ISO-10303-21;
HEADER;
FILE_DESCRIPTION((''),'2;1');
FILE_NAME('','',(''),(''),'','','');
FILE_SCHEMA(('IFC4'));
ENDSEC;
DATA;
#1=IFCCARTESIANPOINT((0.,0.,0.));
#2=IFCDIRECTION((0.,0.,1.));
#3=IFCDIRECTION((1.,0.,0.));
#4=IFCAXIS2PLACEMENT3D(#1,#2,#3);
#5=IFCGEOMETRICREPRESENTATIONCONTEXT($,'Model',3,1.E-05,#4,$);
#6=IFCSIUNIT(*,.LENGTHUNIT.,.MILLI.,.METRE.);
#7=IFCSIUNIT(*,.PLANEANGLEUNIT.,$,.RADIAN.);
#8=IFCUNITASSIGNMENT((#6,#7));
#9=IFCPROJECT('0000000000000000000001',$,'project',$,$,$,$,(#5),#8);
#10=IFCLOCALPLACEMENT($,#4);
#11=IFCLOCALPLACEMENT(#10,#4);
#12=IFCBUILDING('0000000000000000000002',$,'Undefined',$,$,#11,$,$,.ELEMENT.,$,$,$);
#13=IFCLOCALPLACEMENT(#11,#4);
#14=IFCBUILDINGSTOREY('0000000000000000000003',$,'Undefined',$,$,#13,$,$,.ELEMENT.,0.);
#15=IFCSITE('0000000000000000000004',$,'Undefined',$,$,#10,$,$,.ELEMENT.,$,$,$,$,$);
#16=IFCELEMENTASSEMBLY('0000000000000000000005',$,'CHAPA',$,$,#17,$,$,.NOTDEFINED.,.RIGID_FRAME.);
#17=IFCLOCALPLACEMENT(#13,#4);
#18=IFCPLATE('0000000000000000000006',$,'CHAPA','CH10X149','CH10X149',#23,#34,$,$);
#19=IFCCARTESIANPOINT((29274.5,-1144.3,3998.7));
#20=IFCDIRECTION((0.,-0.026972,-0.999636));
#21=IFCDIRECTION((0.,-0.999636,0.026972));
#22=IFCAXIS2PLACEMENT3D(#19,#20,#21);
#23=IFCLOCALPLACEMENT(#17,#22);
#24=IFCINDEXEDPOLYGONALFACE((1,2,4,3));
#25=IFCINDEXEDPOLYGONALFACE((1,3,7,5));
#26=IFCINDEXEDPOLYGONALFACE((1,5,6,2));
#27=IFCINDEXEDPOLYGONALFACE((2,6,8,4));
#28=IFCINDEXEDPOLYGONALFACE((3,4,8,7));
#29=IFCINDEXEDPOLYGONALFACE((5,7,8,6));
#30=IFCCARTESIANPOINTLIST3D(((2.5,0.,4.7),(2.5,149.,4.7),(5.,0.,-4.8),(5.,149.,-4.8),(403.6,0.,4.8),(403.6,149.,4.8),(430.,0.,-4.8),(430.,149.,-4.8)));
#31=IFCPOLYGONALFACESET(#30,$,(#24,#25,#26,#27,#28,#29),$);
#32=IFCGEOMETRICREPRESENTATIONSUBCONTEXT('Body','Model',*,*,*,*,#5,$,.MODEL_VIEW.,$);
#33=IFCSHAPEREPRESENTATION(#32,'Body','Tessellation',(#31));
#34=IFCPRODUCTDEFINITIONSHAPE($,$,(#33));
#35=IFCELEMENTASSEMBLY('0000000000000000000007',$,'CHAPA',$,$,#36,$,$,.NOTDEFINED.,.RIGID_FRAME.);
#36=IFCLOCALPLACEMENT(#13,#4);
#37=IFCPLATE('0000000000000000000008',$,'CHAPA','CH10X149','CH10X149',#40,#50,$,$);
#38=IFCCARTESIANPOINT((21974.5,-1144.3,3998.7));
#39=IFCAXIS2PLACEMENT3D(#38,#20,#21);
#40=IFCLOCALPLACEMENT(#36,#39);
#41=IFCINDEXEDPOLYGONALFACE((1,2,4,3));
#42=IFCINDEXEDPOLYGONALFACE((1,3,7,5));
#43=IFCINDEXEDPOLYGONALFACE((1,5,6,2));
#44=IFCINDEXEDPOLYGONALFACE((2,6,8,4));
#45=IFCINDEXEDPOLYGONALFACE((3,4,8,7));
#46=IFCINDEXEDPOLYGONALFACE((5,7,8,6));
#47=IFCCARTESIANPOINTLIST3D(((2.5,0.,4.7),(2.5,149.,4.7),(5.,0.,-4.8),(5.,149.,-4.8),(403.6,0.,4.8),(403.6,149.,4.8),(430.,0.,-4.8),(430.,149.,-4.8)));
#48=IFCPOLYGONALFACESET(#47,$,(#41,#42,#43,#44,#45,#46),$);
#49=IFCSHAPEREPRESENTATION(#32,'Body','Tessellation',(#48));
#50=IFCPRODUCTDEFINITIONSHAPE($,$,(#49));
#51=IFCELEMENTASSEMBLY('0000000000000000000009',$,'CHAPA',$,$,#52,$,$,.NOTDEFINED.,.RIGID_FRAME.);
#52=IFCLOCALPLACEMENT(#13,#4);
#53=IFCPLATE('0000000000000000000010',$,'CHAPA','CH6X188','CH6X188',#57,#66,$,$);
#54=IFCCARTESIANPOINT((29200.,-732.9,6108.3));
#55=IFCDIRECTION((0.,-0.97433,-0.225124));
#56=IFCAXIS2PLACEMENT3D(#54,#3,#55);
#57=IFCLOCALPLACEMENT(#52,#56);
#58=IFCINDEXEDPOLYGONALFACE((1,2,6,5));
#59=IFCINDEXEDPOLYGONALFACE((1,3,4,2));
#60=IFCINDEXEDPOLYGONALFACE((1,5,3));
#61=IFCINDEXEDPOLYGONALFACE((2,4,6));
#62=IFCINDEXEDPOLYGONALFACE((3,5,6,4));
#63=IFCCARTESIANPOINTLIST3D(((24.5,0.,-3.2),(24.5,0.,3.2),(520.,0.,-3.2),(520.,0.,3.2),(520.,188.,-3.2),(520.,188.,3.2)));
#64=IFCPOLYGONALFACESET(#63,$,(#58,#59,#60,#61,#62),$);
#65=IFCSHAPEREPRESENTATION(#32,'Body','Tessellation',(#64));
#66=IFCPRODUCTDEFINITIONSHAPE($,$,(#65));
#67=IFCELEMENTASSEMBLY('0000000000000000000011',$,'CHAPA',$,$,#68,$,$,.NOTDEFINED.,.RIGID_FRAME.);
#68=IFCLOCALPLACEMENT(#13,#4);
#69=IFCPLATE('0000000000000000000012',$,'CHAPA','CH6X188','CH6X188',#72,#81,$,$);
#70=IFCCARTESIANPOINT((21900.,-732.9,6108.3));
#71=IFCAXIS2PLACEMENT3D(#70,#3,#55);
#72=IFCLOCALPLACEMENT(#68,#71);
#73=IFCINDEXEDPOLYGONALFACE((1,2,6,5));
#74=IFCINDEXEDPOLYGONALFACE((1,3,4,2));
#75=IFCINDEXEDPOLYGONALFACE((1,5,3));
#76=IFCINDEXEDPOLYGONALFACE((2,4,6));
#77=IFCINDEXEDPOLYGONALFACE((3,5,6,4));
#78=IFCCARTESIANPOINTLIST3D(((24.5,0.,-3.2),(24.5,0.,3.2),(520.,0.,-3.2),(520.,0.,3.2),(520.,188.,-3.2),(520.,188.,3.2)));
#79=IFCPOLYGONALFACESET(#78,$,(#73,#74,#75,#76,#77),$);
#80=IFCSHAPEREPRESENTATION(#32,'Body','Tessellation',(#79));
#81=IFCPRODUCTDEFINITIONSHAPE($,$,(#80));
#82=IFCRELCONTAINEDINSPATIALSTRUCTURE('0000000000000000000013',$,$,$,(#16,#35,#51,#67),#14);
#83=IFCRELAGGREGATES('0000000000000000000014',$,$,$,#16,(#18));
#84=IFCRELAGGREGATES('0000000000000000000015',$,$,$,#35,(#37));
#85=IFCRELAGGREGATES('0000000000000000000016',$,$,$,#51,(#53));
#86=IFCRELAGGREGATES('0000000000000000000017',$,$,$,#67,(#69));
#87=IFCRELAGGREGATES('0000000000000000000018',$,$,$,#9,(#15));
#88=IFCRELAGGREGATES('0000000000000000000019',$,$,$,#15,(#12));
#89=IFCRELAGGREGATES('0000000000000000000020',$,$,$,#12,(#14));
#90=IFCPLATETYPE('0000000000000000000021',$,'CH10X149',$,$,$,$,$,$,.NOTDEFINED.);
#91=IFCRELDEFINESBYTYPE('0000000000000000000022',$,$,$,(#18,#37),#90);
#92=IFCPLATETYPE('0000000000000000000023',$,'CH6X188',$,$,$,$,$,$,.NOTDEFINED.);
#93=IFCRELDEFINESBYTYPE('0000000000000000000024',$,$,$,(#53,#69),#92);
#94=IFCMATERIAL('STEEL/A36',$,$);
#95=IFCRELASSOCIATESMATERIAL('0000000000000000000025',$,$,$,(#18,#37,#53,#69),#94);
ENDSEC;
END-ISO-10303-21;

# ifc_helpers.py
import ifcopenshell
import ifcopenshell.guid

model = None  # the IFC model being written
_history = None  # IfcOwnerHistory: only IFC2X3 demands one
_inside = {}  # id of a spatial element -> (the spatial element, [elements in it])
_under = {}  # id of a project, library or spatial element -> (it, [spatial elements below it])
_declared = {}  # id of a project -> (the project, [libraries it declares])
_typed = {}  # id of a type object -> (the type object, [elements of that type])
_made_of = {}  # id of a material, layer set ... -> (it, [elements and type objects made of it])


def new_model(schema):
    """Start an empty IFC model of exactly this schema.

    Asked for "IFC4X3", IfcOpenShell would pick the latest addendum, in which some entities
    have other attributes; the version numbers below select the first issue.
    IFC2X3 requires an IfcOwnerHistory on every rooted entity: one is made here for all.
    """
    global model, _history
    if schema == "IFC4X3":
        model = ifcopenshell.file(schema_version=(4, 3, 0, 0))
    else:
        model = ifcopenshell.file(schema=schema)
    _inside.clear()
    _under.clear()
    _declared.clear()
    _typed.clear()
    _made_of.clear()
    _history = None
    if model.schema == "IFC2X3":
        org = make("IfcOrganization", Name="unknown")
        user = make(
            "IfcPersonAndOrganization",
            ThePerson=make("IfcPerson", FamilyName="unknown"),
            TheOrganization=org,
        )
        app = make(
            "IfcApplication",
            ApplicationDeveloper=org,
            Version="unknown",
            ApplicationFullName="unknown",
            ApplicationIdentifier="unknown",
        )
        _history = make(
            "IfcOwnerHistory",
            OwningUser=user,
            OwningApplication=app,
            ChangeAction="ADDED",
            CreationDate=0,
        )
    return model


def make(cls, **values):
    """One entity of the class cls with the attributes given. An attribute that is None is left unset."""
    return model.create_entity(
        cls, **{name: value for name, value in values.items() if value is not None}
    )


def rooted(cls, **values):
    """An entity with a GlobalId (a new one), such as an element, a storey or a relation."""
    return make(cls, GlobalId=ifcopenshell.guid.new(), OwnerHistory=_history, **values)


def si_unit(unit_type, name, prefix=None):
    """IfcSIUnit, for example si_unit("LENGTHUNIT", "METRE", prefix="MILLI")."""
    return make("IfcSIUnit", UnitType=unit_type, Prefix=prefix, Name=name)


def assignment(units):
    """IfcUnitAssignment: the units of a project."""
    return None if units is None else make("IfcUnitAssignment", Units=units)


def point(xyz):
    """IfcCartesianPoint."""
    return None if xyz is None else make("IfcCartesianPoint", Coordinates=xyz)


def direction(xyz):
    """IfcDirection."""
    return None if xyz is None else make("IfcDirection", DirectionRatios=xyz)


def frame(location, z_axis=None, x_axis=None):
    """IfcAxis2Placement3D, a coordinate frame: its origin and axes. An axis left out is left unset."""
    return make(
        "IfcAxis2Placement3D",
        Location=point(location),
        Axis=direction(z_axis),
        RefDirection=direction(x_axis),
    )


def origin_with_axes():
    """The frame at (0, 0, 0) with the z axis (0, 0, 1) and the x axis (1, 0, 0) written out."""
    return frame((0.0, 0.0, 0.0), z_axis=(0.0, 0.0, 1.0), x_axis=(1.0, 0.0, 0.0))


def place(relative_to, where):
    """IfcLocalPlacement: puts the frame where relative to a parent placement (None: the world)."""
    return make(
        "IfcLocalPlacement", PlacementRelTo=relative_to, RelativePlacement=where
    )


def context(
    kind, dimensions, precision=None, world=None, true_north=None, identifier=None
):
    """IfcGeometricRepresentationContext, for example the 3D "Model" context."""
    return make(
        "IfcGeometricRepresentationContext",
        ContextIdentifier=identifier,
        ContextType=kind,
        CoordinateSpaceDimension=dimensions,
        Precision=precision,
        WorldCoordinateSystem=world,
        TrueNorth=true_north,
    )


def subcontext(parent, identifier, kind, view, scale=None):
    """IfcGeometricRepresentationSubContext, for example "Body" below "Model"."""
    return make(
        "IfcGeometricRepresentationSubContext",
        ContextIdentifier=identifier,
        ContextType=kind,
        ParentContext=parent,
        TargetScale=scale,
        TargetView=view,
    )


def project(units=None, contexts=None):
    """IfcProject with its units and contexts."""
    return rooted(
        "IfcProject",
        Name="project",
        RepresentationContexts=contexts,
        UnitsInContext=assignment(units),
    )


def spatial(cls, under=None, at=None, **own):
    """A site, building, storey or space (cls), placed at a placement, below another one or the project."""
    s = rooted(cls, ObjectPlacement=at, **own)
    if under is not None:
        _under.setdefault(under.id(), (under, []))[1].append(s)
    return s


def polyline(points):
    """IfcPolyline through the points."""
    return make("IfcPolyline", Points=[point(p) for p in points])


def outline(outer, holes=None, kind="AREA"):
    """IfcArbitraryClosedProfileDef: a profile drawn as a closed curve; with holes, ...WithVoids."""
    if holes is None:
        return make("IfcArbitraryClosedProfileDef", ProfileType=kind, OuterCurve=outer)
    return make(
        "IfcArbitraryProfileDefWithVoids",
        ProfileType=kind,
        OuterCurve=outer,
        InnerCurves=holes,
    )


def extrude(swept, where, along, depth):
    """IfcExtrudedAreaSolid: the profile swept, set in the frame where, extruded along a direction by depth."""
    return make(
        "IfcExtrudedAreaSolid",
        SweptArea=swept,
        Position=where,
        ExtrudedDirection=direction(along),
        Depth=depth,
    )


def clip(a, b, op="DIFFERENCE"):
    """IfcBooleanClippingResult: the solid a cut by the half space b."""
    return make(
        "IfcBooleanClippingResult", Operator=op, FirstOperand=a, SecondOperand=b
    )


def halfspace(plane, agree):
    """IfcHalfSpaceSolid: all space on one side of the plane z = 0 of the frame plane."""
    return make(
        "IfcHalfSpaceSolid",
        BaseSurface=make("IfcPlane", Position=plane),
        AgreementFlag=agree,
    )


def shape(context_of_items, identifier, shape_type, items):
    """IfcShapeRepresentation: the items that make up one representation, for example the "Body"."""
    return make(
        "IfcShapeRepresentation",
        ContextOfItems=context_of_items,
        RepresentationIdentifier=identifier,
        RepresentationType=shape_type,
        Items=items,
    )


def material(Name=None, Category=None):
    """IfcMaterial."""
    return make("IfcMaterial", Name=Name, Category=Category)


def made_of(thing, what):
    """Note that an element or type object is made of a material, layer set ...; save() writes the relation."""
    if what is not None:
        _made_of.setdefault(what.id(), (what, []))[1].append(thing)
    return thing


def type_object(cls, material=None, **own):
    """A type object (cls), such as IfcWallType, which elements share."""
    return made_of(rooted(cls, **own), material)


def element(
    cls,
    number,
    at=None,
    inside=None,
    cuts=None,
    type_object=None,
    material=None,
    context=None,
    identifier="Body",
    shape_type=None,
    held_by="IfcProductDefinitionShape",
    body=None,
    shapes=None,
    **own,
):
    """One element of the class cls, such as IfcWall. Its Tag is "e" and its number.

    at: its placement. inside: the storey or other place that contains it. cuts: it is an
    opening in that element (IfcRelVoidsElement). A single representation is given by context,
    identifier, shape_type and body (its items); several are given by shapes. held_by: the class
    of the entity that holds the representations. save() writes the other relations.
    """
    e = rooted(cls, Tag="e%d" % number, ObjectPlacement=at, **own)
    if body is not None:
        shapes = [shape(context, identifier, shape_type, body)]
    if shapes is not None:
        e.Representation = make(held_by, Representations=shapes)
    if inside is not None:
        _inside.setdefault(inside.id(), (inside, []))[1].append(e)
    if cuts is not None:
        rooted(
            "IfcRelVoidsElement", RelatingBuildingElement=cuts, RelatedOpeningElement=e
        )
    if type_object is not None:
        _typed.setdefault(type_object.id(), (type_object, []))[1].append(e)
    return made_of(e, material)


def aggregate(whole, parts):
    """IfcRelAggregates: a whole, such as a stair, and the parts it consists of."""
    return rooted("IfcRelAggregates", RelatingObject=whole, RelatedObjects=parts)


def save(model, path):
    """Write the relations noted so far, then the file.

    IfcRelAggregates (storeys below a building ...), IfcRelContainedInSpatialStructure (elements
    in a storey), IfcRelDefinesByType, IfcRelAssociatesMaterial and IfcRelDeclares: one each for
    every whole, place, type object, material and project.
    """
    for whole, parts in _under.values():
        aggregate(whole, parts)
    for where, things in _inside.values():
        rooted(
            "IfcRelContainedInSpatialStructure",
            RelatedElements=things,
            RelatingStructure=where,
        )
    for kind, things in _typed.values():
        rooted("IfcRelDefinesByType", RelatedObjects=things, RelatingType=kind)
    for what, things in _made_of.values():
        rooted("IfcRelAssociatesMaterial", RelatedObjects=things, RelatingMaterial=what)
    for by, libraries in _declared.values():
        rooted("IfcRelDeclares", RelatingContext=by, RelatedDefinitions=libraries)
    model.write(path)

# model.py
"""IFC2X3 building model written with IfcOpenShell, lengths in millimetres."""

from ifc_helpers import new_model, si_unit, frame, origin_with_axes, place, context, subcontext, project, spatial, polyline, outline, extrude, clip, halfspace, material, type_object, element, aggregate, save


model = new_model("IFC2X3")

# Units and contexts
model_context = context("Model", 3, precision=1e-05, world=origin_with_axes())
body_context = subcontext(model_context, "Body", "Model", "MODEL_VIEW")
ifc_project = project(units=[si_unit("LENGTHUNIT", "METRE", prefix="MILLI"), si_unit("PLANEANGLEUNIT", "RADIAN")], contexts=[model_context])

# Site, building, storey
site_placement = place(None, origin_with_axes())
site = spatial("IfcSite", under=ifc_project, at=site_placement, Name="Undefined", CompositionType="ELEMENT")
building_placement = place(site_placement, origin_with_axes())
building = spatial("IfcBuilding", under=site, at=building_placement, Name="Undefined", CompositionType="ELEMENT")
storey_placement = place(building_placement, origin_with_axes())
storey = spatial("IfcBuildingStorey", under=building, at=storey_placement, Name="Undefined", CompositionType="ELEMENT", Elevation=0.0)

# Shared definitions
ifc_material_1 = material(Name="STEEL/A36")

# Element assemblies, plates
plate_type_1 = type_object("IfcPlateType", Name="CH10X149", PredefinedType="NOTDEFINED")
assembly_1_placement = place(storey_placement, origin_with_axes())
assembly_1 = element("IfcElementAssembly", 1, at=assembly_1_placement, inside=storey, Name="CHAPA", AssemblyPlace="NOTDEFINED", PredefinedType="RIGID_FRAME")
plate_1_placement = place(assembly_1_placement, frame((29274.5, -1144.3, 3998.7), z_axis=(0.0, -0.026972, -0.999636), x_axis=(0.0, -0.999636, 0.026972)))
plate_1 = element("IfcPlate", 2, at=plate_1_placement, type_object=plate_type_1, material=ifc_material_1, Name="CHAPA", Description="CH10X149", ObjectType="CH10X149", context=body_context, shape_type="Clipping", body=[
    clip(clip(extrude(outline(polyline([(0.0, 0.0), (430.0, 0.0), (430.0, 149.0), (0.0, 149.0), (0.0, 0.0)])), frame((0.0, 0.0, -4.8), z_axis=(0.0, 0.0, 1.0), x_axis=(1.0, 0.0, 0.0)), (0.0, 0.0, 1.0), 9.5), halfspace(frame((403.6, -500.0, 4.7), z_axis=(0.33881, 0.0, 0.940855), x_axis=(0.0, 1.0, 0.0)), False)), halfspace(frame((5.0, -500.0, -4.8), z_axis=(-0.965989, 0.0, -0.258583), x_axis=(0.0, 1.0, 0.0)), False)),
])
aggregate(assembly_1, [plate_1])
assembly_2_placement = place(storey_placement, origin_with_axes())
assembly_2 = element("IfcElementAssembly", 3, at=assembly_2_placement, inside=storey, Name="CHAPA", AssemblyPlace="NOTDEFINED", PredefinedType="RIGID_FRAME")
plate_2_placement = place(assembly_2_placement, frame((21974.5, -1144.3, 3998.7), z_axis=(0.0, -0.026972, -0.999636), x_axis=(0.0, -0.999636, 0.026972)))
plate_2 = element("IfcPlate", 4, at=plate_2_placement, type_object=plate_type_1, material=ifc_material_1, Name="CHAPA", Description="CH10X149", ObjectType="CH10X149", context=body_context, shape_type="Clipping", body=[
    clip(clip(extrude(outline(polyline([(0.0, 0.0), (430.0, 0.0), (430.0, 149.0), (0.0, 149.0), (0.0, 0.0)])), frame((0.0, 0.0, -4.8), z_axis=(0.0, 0.0, 1.0), x_axis=(1.0, 0.0, 0.0)), (0.0, 0.0, 1.0), 9.5), halfspace(frame((403.6, -500.0, 4.7), z_axis=(0.33881, 0.0, 0.940855), x_axis=(0.0, 1.0, 0.0)), False)), halfspace(frame((5.0, -500.0, -4.8), z_axis=(-0.965989, 0.0, -0.258583), x_axis=(0.0, 1.0, 0.0)), False)),
])
aggregate(assembly_2, [plate_2])
assembly_3_placement = place(storey_placement, origin_with_axes())
assembly_3 = element("IfcElementAssembly", 5, at=assembly_3_placement, inside=storey, Name="CHAPA", AssemblyPlace="NOTDEFINED", PredefinedType="RIGID_FRAME")
plate_type_2 = type_object("IfcPlateType", Name="CH6X188", PredefinedType="NOTDEFINED")
plate_3_placement = place(assembly_3_placement, frame((29200.0, -732.9, 6108.3), z_axis=(1.0, 0.0, 0.0), x_axis=(0.0, -0.97433, -0.225124)))
plate_3 = element("IfcPlate", 6, at=plate_3_placement, type_object=plate_type_2, material=ifc_material_1, Name="CHAPA", Description="CH6X188", ObjectType="CH6X188", context=body_context, shape_type="Clipping", body=[
    clip(extrude(outline(polyline([(0.0, 0.0), (520.0, 0.0), (520.0, 191.6), (0.0, 0.0)])), frame((0.0, 0.0, -3.1), z_axis=(0.0, 0.0, 1.0), x_axis=(1.0, 0.0, 0.0)), (0.0, 0.0, 1.0), 6.3), halfspace(frame((1342.2, 500.0, 3.2), z_axis=(-0.354778, 0.934951, 0.0), x_axis=(-0.934951, -0.354778, 0.0)), False)),
])
aggregate(assembly_3, [plate_3])
assembly_4_placement = place(storey_placement, origin_with_axes())
assembly_4 = element("IfcElementAssembly", 7, at=assembly_4_placement, inside=storey, Name="CHAPA", AssemblyPlace="NOTDEFINED", PredefinedType="RIGID_FRAME")
plate_4_placement = place(assembly_4_placement, frame((21900.0, -732.9, 6108.3), z_axis=(1.0, 0.0, 0.0), x_axis=(0.0, -0.97433, -0.225124)))
plate_4 = element("IfcPlate", 8, at=plate_4_placement, type_object=plate_type_2, material=ifc_material_1, Name="CHAPA", Description="CH6X188", ObjectType="CH6X188", context=body_context, shape_type="Clipping", body=[
    clip(extrude(outline(polyline([(0.0, 0.0), (520.0, 0.0), (520.0, 191.6), (0.0, 0.0)])), frame((0.0, 0.0, -3.1), z_axis=(0.0, 0.0, 1.0), x_axis=(1.0, 0.0, 0.0)), (0.0, 0.0, 1.0), 6.3), halfspace(frame((1342.2, 500.0, 3.2), z_axis=(-0.354778, 0.934951, 0.0), x_axis=(-0.934951, -0.354778, 0.0)), False)),
])
aggregate(assembly_4, [plate_4])

save(model, "model.ifc")
